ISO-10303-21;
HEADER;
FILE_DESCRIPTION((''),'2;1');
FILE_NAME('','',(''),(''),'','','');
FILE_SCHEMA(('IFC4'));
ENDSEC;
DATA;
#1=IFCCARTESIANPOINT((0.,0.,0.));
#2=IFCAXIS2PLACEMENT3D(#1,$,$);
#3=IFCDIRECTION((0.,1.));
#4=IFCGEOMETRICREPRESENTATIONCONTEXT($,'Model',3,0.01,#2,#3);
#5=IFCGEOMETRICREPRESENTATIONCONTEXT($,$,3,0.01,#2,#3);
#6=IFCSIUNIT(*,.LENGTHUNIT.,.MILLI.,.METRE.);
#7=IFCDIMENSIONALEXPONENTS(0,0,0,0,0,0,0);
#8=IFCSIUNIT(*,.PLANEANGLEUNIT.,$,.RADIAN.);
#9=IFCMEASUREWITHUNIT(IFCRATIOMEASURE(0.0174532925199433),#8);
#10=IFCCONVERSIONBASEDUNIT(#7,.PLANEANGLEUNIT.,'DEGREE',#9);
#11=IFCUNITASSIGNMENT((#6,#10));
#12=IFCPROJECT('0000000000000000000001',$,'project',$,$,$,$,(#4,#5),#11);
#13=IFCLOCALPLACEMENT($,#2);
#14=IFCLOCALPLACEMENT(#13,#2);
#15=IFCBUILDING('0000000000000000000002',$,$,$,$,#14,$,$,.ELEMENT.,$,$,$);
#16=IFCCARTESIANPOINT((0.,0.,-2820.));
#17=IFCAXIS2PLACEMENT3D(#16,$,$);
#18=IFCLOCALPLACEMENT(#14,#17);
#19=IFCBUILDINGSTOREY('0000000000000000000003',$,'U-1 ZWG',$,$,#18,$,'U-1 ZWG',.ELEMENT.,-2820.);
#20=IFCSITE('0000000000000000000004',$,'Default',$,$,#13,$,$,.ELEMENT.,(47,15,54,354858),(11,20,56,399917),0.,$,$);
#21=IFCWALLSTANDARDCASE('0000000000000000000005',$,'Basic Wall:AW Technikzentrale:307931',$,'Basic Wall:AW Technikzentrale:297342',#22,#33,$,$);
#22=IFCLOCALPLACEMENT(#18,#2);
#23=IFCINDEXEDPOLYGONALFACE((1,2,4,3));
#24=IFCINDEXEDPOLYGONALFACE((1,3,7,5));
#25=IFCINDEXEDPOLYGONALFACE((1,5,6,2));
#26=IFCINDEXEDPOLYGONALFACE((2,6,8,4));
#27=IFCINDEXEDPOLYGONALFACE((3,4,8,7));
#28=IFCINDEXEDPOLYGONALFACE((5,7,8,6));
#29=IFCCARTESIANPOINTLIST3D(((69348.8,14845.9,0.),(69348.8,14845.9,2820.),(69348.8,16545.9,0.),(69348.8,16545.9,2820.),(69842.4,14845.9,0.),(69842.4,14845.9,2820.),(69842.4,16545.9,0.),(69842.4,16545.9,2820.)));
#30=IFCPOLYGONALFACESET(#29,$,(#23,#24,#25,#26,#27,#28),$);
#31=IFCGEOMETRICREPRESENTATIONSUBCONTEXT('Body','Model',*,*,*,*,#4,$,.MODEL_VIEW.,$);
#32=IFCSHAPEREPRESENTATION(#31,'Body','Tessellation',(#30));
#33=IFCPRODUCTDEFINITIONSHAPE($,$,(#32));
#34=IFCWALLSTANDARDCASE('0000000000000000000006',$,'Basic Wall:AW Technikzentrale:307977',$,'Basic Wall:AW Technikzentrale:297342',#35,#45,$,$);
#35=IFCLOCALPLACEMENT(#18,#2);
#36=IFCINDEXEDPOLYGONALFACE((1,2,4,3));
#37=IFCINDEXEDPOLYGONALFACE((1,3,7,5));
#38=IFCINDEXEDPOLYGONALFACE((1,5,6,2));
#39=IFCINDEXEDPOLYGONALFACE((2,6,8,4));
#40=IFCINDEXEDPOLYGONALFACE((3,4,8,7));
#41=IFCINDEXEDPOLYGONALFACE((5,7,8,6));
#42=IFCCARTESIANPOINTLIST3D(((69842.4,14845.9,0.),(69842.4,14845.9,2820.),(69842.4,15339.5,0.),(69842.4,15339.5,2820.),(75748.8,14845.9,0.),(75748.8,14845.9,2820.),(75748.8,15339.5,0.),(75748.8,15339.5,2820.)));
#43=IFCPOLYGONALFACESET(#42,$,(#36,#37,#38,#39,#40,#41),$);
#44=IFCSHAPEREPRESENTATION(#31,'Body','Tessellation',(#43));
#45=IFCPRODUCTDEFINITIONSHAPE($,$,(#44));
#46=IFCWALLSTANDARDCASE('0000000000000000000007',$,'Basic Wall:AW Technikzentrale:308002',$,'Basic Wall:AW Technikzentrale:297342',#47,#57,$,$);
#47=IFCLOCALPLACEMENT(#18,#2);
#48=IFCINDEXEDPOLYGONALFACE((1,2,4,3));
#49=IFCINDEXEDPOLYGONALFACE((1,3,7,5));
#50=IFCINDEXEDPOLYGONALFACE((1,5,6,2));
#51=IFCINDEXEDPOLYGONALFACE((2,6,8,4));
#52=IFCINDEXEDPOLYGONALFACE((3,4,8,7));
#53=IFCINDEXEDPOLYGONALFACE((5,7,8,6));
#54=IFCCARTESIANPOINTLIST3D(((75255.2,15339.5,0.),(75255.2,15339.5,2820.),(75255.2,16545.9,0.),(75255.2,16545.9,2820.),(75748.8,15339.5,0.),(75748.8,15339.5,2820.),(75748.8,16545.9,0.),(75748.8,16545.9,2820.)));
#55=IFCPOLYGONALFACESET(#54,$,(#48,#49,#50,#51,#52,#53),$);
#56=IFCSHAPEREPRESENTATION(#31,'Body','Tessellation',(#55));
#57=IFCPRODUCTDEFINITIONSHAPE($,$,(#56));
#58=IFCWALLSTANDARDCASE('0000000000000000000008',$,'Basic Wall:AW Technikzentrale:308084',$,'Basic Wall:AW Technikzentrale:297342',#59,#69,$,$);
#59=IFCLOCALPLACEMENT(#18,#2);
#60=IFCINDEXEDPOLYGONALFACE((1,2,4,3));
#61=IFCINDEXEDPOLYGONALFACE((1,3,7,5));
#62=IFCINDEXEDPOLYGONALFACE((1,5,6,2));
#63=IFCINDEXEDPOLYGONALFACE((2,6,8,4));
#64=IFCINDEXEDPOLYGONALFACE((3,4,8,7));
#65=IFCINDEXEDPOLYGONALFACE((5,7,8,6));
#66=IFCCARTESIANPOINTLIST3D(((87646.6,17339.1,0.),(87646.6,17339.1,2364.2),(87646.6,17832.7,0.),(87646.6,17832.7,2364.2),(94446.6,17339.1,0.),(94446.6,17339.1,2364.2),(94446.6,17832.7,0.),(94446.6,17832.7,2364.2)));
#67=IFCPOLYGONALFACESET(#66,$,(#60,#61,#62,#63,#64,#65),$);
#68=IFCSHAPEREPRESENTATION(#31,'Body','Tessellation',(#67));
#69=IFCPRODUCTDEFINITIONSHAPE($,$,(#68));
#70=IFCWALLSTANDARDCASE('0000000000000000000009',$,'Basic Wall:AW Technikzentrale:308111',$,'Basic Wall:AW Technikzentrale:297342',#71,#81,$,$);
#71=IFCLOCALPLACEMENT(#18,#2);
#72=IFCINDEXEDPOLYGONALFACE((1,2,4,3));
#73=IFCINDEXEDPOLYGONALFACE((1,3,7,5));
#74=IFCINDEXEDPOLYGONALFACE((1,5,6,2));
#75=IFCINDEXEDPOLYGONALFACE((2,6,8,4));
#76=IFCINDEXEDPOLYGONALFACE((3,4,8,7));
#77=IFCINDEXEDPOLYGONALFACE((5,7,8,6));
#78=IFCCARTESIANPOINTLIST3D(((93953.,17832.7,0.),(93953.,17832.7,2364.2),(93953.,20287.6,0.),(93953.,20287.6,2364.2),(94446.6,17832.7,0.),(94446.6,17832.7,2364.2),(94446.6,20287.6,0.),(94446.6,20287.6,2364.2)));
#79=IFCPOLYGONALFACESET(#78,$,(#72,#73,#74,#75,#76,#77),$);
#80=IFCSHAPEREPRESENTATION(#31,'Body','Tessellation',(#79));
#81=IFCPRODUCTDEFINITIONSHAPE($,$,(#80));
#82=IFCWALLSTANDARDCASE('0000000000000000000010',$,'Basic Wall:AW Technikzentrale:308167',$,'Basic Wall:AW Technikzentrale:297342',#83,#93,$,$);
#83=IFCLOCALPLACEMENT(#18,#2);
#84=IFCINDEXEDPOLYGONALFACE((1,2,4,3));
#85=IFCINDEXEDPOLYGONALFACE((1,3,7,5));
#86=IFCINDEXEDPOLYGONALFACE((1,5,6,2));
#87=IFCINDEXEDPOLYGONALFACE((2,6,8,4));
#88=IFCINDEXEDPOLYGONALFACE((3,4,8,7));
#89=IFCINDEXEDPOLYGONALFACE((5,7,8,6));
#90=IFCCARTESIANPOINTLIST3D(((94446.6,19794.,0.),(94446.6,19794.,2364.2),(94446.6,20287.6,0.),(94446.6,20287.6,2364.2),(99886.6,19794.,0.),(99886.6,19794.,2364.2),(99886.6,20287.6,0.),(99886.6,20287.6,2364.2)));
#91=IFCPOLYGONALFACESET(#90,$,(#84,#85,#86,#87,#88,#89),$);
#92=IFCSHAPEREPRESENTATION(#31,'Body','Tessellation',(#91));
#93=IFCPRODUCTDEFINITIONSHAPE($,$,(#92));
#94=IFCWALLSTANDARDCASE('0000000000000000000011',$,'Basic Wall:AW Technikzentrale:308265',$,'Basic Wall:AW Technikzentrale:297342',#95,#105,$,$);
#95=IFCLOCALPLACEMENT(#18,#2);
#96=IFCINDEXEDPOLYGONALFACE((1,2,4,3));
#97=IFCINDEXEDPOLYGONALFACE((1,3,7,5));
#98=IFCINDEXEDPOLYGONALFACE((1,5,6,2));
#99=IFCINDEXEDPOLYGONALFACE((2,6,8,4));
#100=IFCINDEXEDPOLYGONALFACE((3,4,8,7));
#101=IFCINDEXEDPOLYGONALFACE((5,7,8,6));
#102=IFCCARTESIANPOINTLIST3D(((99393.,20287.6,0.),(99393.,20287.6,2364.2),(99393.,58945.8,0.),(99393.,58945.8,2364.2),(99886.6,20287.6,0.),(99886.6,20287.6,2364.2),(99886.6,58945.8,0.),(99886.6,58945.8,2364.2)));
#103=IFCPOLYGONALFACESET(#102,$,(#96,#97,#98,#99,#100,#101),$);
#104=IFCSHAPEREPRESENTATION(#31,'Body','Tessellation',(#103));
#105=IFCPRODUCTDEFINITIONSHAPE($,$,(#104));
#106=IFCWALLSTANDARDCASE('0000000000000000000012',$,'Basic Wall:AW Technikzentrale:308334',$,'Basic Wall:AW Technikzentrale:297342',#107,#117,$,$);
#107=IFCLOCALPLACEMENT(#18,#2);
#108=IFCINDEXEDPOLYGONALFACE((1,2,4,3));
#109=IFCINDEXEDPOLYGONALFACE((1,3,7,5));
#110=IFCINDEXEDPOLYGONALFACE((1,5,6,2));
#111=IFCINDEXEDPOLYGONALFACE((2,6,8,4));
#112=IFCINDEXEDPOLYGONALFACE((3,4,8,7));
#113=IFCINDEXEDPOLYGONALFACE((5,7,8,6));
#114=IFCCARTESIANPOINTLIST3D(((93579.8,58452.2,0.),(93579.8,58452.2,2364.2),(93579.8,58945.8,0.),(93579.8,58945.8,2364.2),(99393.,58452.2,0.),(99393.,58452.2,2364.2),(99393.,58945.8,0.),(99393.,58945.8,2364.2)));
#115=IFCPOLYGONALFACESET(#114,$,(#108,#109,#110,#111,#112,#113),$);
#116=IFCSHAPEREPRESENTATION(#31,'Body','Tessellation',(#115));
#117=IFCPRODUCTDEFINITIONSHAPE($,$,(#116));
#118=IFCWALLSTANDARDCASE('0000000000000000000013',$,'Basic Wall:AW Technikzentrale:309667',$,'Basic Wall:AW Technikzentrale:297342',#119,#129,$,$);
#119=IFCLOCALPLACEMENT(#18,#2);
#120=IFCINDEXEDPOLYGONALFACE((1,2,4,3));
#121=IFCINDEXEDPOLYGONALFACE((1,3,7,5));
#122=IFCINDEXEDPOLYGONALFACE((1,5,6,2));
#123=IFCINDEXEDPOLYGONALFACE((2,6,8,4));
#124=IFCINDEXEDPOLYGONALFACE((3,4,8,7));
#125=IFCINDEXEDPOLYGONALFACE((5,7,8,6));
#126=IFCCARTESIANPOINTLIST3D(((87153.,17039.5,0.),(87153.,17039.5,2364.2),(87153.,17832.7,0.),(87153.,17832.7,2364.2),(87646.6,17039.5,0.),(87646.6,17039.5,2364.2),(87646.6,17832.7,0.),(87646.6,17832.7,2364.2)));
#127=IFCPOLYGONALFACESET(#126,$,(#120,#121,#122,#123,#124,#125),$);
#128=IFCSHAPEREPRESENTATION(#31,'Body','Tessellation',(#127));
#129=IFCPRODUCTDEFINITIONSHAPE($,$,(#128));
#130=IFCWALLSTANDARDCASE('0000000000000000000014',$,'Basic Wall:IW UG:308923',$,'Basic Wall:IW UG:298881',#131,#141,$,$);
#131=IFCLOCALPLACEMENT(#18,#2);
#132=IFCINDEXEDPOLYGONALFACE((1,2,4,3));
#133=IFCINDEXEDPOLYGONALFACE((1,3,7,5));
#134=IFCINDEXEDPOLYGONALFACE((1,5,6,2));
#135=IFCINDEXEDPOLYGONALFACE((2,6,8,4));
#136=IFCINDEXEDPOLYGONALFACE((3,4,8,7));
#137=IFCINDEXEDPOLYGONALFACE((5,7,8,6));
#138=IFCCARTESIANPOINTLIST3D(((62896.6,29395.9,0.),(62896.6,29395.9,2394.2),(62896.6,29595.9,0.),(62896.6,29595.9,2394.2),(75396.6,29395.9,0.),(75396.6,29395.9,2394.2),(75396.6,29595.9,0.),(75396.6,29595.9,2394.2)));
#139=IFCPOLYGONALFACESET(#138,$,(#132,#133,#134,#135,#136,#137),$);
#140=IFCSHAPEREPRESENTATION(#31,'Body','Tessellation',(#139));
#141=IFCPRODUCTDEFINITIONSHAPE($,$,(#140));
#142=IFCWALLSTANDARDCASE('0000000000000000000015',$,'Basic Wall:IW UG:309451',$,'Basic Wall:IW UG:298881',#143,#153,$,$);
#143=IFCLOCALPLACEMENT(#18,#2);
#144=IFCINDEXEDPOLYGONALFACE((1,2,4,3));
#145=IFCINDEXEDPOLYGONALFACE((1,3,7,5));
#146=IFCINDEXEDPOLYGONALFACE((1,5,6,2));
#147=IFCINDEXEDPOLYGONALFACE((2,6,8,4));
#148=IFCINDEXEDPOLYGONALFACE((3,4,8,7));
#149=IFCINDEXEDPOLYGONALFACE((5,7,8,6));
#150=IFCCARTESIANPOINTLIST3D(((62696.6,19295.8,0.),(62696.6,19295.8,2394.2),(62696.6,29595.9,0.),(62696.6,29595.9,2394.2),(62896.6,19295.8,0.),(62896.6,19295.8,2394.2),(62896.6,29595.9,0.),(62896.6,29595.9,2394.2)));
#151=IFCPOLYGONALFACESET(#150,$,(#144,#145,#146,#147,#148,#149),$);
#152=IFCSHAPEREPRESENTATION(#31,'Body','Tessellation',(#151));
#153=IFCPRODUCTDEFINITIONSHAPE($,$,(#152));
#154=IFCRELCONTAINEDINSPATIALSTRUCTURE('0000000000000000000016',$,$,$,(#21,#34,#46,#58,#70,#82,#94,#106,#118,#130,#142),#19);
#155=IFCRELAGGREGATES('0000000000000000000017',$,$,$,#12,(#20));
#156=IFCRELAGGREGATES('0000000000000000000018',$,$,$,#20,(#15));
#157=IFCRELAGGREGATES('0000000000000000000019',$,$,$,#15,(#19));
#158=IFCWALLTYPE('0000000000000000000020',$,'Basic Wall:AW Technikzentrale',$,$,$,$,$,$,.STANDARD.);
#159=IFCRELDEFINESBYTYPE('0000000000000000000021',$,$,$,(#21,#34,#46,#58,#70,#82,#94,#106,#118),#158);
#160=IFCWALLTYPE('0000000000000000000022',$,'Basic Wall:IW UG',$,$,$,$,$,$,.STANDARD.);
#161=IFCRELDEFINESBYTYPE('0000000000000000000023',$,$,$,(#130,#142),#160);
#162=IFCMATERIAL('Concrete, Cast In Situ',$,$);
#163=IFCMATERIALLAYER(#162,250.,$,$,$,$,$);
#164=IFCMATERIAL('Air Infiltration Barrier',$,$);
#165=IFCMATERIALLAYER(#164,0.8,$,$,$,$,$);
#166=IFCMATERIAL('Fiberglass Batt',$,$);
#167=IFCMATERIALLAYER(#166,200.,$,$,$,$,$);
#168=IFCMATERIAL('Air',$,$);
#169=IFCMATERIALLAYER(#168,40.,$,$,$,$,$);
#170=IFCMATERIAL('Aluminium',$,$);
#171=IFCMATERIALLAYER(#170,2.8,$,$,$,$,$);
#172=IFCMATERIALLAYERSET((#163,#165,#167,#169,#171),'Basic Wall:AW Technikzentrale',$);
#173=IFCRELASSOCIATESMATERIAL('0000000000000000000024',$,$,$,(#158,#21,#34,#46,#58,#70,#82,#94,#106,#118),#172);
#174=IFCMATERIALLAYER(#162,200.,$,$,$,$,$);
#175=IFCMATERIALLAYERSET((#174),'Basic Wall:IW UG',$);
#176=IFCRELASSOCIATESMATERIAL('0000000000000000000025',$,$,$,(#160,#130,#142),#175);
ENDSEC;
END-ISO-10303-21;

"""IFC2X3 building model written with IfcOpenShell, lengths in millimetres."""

from ifc_helpers import new_model, entity, si_unit, converted_unit, direction, frame, frame_2d, origin, place, context, subcontext, project, spatial, polyline, rectangle, extrude, clip, bounded_halfspace, material, layer, layer_set, layer_usage, type_object, element, save


model = new_model("IFC2X3")

# Units and contexts
model_context = context("Model", 3, precision=0.01, world=origin(), true_north=direction((0.0, 1.0)))
context_of_model = context(None, 3, precision=0.01, world=origin(), true_north=direction((0.0, 1.0)))
body_context = subcontext(model_context, "Body", "Model", "MODEL_VIEW")
ifc_project = project(units=[si_unit("LENGTHUNIT", "METRE", prefix="MILLI"), converted_unit("PLANEANGLEUNIT", "DEGREE", entity("IfcRatioMeasure", 0.0174532925199433), si_unit("PLANEANGLEUNIT", "RADIAN"), dimensions=[0, 0, 0, 0, 0, 0, 0])], contexts=[model_context, context_of_model])

# Site, building, storey
site_placement = place(None, origin())
site = spatial("IfcSite", under=ifc_project, at=site_placement, Name="Default", CompositionType="ELEMENT", RefLatitude=(47, 15, 54, 354858), RefLongitude=(11, 20, 56, 399917), RefElevation=0.0)
building_placement = place(site_placement, origin())
building = spatial("IfcBuilding", under=site, at=building_placement, CompositionType="ELEMENT")
storey_placement = place(building_placement, frame((0.0, 0.0, -2820.0)))
storey = spatial("IfcBuildingStorey", under=building, at=storey_placement, Name="U-1 ZWG", LongName="U-1 ZWG", CompositionType="ELEMENT", Elevation=-2820.0)

# Shared definitions
ifc_material_1 = material(Name="Air Infiltration Barrier")
ifc_material_2 = material(Name="Fiberglass Batt")
ifc_material_3 = material(Name="Aluminium")

# Walls
ifc_material_4 = material(Name="Concrete, Cast In Situ")
ifc_layer_1 = layer(ifc_material_4, 250.0)
ifc_layer_2 = layer(ifc_material_1, 0.8)
ifc_layer_3 = layer(ifc_material_2, 200.0)
ifc_material_5 = material(Name="Air")
ifc_layer_4 = layer(ifc_material_5, 40.0)
ifc_layer_5 = layer(ifc_material_3, 2.8)
ifc_layer_set_1 = layer_set([ifc_layer_1, ifc_layer_2, ifc_layer_3, ifc_layer_4, ifc_layer_5], Name="Basic Wall:AW Technikzentrale")
ifc_layer_usage_1 = layer_usage(ifc_layer_set_1, "AXIS2", "NEGATIVE", 246.8)
wall_type_1 = type_object("IfcWallType", Name="Basic Wall:AW Technikzentrale", PredefinedType="STANDARD", material=ifc_layer_set_1)
wall_1_placement = place(storey_placement, frame((69595.6, 16545.9, 0.0), z_axis=(0.0, 0.0, 1.0), x_axis=(0.0, -1.0, 0.0)))
element("IfcWallStandardCase", 1, at=wall_1_placement, inside=storey, type_object=wall_type_1, material=ifc_layer_usage_1, Name="Basic Wall:AW Technikzentrale:307931", ObjectType="Basic Wall:AW Technikzentrale:297342", context=body_context, shape_type="SweptSolid", body=[
    extrude(rectangle(XDim=1700.0, YDim=493.6, at=frame_2d((850.0, 0.0), x_axis=(-1.0, 0.0))), origin(), (0.0, 0.0, 1.0), 2820.0),
])
ifc_layer_usage_2 = layer_usage(ifc_layer_set_1, "AXIS2", "NEGATIVE", 246.8)
wall_2_placement = place(storey_placement, frame((69842.4, 15092.7, 0.0)))
element("IfcWallStandardCase", 2, at=wall_2_placement, inside=storey, type_object=wall_type_1, material=ifc_layer_usage_2, Name="Basic Wall:AW Technikzentrale:307977", ObjectType="Basic Wall:AW Technikzentrale:297342", context=body_context, shape_type="SweptSolid", body=[
    extrude(rectangle(XDim=5906.4, YDim=493.6, at=frame_2d((2953.2, 0.0), x_axis=(-1.0, 0.0))), origin(), (0.0, 0.0, 1.0), 2820.0),
])
ifc_layer_usage_3 = layer_usage(ifc_layer_set_1, "AXIS2", "NEGATIVE", 246.8)
wall_3_placement = place(storey_placement, frame((75502.0, 15339.5, 0.0), z_axis=(0.0, 0.0, 1.0), x_axis=(0.0, 1.0, 0.0)))
element("IfcWallStandardCase", 3, at=wall_3_placement, inside=storey, type_object=wall_type_1, material=ifc_layer_usage_3, Name="Basic Wall:AW Technikzentrale:308002", ObjectType="Basic Wall:AW Technikzentrale:297342", context=body_context, shape_type="SweptSolid", body=[
    extrude(rectangle(XDim=1206.4, YDim=493.6, at=frame_2d((603.2, 0.0), x_axis=(-1.0, 0.0))), origin(), (0.0, 0.0, 1.0), 2820.0),
])
ifc_layer_usage_4 = layer_usage(ifc_layer_set_1, "AXIS2", "NEGATIVE", 246.8)
wall_4_placement = place(storey_placement, frame((87646.6, 17585.9, 0.0)))
element("IfcWallStandardCase", 4, at=wall_4_placement, inside=storey, type_object=wall_type_1, material=ifc_layer_usage_4, Name="Basic Wall:AW Technikzentrale:308084", ObjectType="Basic Wall:AW Technikzentrale:297342", context=body_context, shape_type="Clipping", body=[
    clip(extrude(rectangle(XDim=6800.0, YDim=493.6, at=frame_2d((3400.0, 0.0), x_axis=(-1.0, 0.0))), origin(), (0.0, 0.0, 1.0), 2364.2), bounded_halfspace(frame((0.0, -246.8, 2364.2), z_axis=(0.0, 0.0, -1.0), x_axis=(0.0, 1.0, 0.0)), True, frame((0.0, -246.8, 2364.2)), polyline([(0.0, 0.0), (6800.0, 0.0), (6800.0, 493.6), (6306.4, 493.6), (0.0, 493.6), (0.0, 0.0)]))),
])
ifc_layer_usage_5 = layer_usage(ifc_layer_set_1, "AXIS2", "NEGATIVE", 246.8)
wall_5_placement = place(storey_placement, frame((94199.8, 17832.7, 0.0), z_axis=(0.0, 0.0, 1.0), x_axis=(0.0, 1.0, 0.0)))
element("IfcWallStandardCase", 5, at=wall_5_placement, inside=storey, type_object=wall_type_1, material=ifc_layer_usage_5, Name="Basic Wall:AW Technikzentrale:308111", ObjectType="Basic Wall:AW Technikzentrale:297342", context=body_context, shape_type="Clipping", body=[
    clip(extrude(rectangle(XDim=2455.0, YDim=493.6, at=frame_2d((1227.5, 0.0), x_axis=(-1.0, 0.0))), origin(), (0.0, 0.0, 1.0), 2364.2), bounded_halfspace(frame((0.0, -246.8, 2364.2), z_axis=(0.0, 0.0, -1.0), x_axis=(1.0, 0.0, 0.0)), True, frame((0.0, -246.8, 2364.2)), polyline([(0.0, 0.0), (1961.4, 0.0), (2455.0, 0.0), (2455.0, 493.6), (0.0, 493.6), (0.0, 0.0)]))),
])
ifc_layer_usage_6 = layer_usage(ifc_layer_set_1, "AXIS2", "NEGATIVE", 246.8)
wall_6_placement = place(storey_placement, frame((94446.6, 20040.8, 0.0)))
element("IfcWallStandardCase", 6, at=wall_6_placement, inside=storey, type_object=wall_type_1, material=ifc_layer_usage_6, Name="Basic Wall:AW Technikzentrale:308167", ObjectType="Basic Wall:AW Technikzentrale:297342", context=body_context, shape_type="Clipping", body=[
    clip(extrude(rectangle(XDim=5440.0, YDim=493.6, at=frame_2d((2720.0, 0.0), x_axis=(-1.0, 0.0))), origin(), (0.0, 0.0, 1.0), 2364.2), bounded_halfspace(frame((0.0, -246.8, 2364.2), z_axis=(0.0, 0.0, -1.0), x_axis=(0.0, 1.0, 0.0)), True, frame((0.0, -246.8, 2364.2)), polyline([(0.0, 0.0), (5440.0, 0.0), (5440.0, 493.6), (4946.4, 493.6), (0.0, 493.6), (0.0, 0.0)]))),
])
ifc_layer_usage_7 = layer_usage(ifc_layer_set_1, "AXIS2", "NEGATIVE", 246.8)
wall_7_placement = place(storey_placement, frame((99639.8, 20287.6, 0.0), z_axis=(0.0, 0.0, 1.0), x_axis=(0.0, 1.0, 0.0)))
element("IfcWallStandardCase", 7, at=wall_7_placement, inside=storey, type_object=wall_type_1, material=ifc_layer_usage_7, Name="Basic Wall:AW Technikzentrale:308265", ObjectType="Basic Wall:AW Technikzentrale:297342", context=body_context, shape_type="Clipping", body=[
    clip(extrude(rectangle(XDim=38658.2, YDim=493.6, at=frame_2d((19329.1, 0.0), x_axis=(-1.0, 0.0))), origin(), (0.0, 0.0, 1.0), 2364.2), bounded_halfspace(frame((0.0, -246.8, 2364.2), z_axis=(0.0, 0.0, -1.0), x_axis=(1.0, 0.0, 0.0)), True, frame((0.0, -246.8, 2364.2)), polyline([(0.0, 0.0), (38658.2, 0.0), (38658.2, 493.6), (38164.6, 493.6), (0.0, 493.6), (0.0, 0.0)]))),
])
ifc_layer_usage_8 = layer_usage(ifc_layer_set_1, "AXIS2", "NEGATIVE", 246.8)
wall_8_placement = place(storey_placement, frame((99393.0, 58699.0, 0.0), z_axis=(0.0, 0.0, 1.0), x_axis=(-1.0, 0.0, 0.0)))
element("IfcWallStandardCase", 8, at=wall_8_placement, inside=storey, type_object=wall_type_1, material=ifc_layer_usage_8, Name="Basic Wall:AW Technikzentrale:308334", ObjectType="Basic Wall:AW Technikzentrale:297342", context=body_context, shape_type="Clipping", body=[
    clip(extrude(rectangle(XDim=5813.2, YDim=493.6, at=frame_2d((2906.6, 0.0), x_axis=(-1.0, 0.0))), origin(), (0.0, 0.0, 1.0), 2364.2), bounded_halfspace(frame((0.0, -246.8, 2364.2), z_axis=(0.0, 0.0, -1.0), x_axis=(0.0, -1.0, 0.0)), True, frame((0.0, -246.8, 2364.2)), polyline([(0.0, 0.0), (5813.2, 0.0), (5813.2, 493.6), (0.0, 493.6), (0.0, 0.0)]))),
])
ifc_layer_usage_9 = layer_usage(ifc_layer_set_1, "AXIS2", "NEGATIVE", 246.8)
wall_9_placement = place(storey_placement, frame((87399.8, 17039.5, 0.0), z_axis=(0.0, 0.0, 1.0), x_axis=(0.0, 1.0, 0.0)))
element("IfcWallStandardCase", 9, at=wall_9_placement, inside=storey, type_object=wall_type_1, material=ifc_layer_usage_9, Name="Basic Wall:AW Technikzentrale:309667", ObjectType="Basic Wall:AW Technikzentrale:297342", context=body_context, shape_type="Clipping", body=[
    clip(extrude(rectangle(XDim=793.2, YDim=493.6, at=frame_2d((396.6, 0.0), x_axis=(-1.0, 0.0))), origin(), (0.0, 0.0, 1.0), 2364.2), bounded_halfspace(frame((0.0, -246.8, 2364.2), z_axis=(0.0, 0.0, -1.0), x_axis=(1.0, 0.0, 0.0)), True, frame((0.0, -246.8, 2364.2)), polyline([(0.0, 0.0), (299.6, 0.0), (793.2, 0.0), (793.2, 493.6), (0.0, 493.6), (0.0, 0.0)]))),
])
ifc_layer_6 = layer(ifc_material_4, 200.0)
ifc_layer_set_2 = layer_set([ifc_layer_6], Name="Basic Wall:IW UG")
ifc_layer_usage_10 = layer_usage(ifc_layer_set_2, "AXIS2", "NEGATIVE", 100.0)
wall_type_2 = type_object("IfcWallType", Name="Basic Wall:IW UG", PredefinedType="STANDARD", material=ifc_layer_set_2)
wall_10_placement = place(storey_placement, frame((62896.6, 29495.9, 0.0)))
element("IfcWallStandardCase", 10, at=wall_10_placement, inside=storey, type_object=wall_type_2, material=ifc_layer_usage_10, Name="Basic Wall:IW UG:308923", ObjectType="Basic Wall:IW UG:298881", context=body_context, shape_type="Clipping", body=[
    clip(extrude(rectangle(XDim=12500.0, YDim=200.0, at=frame_2d((6250.0, 0.0), x_axis=(-1.0, 0.0))), origin(), (0.0, 0.0, 1.0), 2394.2), bounded_halfspace(frame((0.0, -100.0, 2394.2), z_axis=(0.0, 0.0, -1.0), x_axis=(1.0, 0.0, 0.0)), True, frame((0.0, -100.0, 2394.2)), polyline([(0.0, 0.0), (12500.0, 0.0), (12500.0, 200.0), (0.0, 200.0), (0.0, 0.0)]))),
])
ifc_layer_usage_11 = layer_usage(ifc_layer_set_2, "AXIS2", "NEGATIVE", 100.0)
wall_11_placement = place(storey_placement, frame((62796.6, 19295.8, 0.0), z_axis=(0.0, 0.0, 1.0), x_axis=(0.0, 1.0, 0.0)))
element("IfcWallStandardCase", 11, at=wall_11_placement, inside=storey, type_object=wall_type_2, material=ifc_layer_usage_11, Name="Basic Wall:IW UG:309451", ObjectType="Basic Wall:IW UG:298881", context=body_context, shape_type="Clipping", body=[
    clip(extrude(rectangle(XDim=10300.0, YDim=200.0, at=frame_2d((5150.0, 0.0), x_axis=(-1.0, 0.0))), origin(), (0.0, 0.0, 1.0), 2394.2), bounded_halfspace(frame((0.0, -100.0, 2394.2), z_axis=(0.0, 0.0, -1.0), x_axis=(0.0, -1.0, 0.0)), True, frame((0.0, -100.0, 2394.2)), polyline([(0.0, 0.0), (10100.0, 0.0), (10300.0, 0.0), (10300.0, 200.0), (0.0, 200.0), (0.0, 0.0)]))),
])

save(model, "model.ifc")
